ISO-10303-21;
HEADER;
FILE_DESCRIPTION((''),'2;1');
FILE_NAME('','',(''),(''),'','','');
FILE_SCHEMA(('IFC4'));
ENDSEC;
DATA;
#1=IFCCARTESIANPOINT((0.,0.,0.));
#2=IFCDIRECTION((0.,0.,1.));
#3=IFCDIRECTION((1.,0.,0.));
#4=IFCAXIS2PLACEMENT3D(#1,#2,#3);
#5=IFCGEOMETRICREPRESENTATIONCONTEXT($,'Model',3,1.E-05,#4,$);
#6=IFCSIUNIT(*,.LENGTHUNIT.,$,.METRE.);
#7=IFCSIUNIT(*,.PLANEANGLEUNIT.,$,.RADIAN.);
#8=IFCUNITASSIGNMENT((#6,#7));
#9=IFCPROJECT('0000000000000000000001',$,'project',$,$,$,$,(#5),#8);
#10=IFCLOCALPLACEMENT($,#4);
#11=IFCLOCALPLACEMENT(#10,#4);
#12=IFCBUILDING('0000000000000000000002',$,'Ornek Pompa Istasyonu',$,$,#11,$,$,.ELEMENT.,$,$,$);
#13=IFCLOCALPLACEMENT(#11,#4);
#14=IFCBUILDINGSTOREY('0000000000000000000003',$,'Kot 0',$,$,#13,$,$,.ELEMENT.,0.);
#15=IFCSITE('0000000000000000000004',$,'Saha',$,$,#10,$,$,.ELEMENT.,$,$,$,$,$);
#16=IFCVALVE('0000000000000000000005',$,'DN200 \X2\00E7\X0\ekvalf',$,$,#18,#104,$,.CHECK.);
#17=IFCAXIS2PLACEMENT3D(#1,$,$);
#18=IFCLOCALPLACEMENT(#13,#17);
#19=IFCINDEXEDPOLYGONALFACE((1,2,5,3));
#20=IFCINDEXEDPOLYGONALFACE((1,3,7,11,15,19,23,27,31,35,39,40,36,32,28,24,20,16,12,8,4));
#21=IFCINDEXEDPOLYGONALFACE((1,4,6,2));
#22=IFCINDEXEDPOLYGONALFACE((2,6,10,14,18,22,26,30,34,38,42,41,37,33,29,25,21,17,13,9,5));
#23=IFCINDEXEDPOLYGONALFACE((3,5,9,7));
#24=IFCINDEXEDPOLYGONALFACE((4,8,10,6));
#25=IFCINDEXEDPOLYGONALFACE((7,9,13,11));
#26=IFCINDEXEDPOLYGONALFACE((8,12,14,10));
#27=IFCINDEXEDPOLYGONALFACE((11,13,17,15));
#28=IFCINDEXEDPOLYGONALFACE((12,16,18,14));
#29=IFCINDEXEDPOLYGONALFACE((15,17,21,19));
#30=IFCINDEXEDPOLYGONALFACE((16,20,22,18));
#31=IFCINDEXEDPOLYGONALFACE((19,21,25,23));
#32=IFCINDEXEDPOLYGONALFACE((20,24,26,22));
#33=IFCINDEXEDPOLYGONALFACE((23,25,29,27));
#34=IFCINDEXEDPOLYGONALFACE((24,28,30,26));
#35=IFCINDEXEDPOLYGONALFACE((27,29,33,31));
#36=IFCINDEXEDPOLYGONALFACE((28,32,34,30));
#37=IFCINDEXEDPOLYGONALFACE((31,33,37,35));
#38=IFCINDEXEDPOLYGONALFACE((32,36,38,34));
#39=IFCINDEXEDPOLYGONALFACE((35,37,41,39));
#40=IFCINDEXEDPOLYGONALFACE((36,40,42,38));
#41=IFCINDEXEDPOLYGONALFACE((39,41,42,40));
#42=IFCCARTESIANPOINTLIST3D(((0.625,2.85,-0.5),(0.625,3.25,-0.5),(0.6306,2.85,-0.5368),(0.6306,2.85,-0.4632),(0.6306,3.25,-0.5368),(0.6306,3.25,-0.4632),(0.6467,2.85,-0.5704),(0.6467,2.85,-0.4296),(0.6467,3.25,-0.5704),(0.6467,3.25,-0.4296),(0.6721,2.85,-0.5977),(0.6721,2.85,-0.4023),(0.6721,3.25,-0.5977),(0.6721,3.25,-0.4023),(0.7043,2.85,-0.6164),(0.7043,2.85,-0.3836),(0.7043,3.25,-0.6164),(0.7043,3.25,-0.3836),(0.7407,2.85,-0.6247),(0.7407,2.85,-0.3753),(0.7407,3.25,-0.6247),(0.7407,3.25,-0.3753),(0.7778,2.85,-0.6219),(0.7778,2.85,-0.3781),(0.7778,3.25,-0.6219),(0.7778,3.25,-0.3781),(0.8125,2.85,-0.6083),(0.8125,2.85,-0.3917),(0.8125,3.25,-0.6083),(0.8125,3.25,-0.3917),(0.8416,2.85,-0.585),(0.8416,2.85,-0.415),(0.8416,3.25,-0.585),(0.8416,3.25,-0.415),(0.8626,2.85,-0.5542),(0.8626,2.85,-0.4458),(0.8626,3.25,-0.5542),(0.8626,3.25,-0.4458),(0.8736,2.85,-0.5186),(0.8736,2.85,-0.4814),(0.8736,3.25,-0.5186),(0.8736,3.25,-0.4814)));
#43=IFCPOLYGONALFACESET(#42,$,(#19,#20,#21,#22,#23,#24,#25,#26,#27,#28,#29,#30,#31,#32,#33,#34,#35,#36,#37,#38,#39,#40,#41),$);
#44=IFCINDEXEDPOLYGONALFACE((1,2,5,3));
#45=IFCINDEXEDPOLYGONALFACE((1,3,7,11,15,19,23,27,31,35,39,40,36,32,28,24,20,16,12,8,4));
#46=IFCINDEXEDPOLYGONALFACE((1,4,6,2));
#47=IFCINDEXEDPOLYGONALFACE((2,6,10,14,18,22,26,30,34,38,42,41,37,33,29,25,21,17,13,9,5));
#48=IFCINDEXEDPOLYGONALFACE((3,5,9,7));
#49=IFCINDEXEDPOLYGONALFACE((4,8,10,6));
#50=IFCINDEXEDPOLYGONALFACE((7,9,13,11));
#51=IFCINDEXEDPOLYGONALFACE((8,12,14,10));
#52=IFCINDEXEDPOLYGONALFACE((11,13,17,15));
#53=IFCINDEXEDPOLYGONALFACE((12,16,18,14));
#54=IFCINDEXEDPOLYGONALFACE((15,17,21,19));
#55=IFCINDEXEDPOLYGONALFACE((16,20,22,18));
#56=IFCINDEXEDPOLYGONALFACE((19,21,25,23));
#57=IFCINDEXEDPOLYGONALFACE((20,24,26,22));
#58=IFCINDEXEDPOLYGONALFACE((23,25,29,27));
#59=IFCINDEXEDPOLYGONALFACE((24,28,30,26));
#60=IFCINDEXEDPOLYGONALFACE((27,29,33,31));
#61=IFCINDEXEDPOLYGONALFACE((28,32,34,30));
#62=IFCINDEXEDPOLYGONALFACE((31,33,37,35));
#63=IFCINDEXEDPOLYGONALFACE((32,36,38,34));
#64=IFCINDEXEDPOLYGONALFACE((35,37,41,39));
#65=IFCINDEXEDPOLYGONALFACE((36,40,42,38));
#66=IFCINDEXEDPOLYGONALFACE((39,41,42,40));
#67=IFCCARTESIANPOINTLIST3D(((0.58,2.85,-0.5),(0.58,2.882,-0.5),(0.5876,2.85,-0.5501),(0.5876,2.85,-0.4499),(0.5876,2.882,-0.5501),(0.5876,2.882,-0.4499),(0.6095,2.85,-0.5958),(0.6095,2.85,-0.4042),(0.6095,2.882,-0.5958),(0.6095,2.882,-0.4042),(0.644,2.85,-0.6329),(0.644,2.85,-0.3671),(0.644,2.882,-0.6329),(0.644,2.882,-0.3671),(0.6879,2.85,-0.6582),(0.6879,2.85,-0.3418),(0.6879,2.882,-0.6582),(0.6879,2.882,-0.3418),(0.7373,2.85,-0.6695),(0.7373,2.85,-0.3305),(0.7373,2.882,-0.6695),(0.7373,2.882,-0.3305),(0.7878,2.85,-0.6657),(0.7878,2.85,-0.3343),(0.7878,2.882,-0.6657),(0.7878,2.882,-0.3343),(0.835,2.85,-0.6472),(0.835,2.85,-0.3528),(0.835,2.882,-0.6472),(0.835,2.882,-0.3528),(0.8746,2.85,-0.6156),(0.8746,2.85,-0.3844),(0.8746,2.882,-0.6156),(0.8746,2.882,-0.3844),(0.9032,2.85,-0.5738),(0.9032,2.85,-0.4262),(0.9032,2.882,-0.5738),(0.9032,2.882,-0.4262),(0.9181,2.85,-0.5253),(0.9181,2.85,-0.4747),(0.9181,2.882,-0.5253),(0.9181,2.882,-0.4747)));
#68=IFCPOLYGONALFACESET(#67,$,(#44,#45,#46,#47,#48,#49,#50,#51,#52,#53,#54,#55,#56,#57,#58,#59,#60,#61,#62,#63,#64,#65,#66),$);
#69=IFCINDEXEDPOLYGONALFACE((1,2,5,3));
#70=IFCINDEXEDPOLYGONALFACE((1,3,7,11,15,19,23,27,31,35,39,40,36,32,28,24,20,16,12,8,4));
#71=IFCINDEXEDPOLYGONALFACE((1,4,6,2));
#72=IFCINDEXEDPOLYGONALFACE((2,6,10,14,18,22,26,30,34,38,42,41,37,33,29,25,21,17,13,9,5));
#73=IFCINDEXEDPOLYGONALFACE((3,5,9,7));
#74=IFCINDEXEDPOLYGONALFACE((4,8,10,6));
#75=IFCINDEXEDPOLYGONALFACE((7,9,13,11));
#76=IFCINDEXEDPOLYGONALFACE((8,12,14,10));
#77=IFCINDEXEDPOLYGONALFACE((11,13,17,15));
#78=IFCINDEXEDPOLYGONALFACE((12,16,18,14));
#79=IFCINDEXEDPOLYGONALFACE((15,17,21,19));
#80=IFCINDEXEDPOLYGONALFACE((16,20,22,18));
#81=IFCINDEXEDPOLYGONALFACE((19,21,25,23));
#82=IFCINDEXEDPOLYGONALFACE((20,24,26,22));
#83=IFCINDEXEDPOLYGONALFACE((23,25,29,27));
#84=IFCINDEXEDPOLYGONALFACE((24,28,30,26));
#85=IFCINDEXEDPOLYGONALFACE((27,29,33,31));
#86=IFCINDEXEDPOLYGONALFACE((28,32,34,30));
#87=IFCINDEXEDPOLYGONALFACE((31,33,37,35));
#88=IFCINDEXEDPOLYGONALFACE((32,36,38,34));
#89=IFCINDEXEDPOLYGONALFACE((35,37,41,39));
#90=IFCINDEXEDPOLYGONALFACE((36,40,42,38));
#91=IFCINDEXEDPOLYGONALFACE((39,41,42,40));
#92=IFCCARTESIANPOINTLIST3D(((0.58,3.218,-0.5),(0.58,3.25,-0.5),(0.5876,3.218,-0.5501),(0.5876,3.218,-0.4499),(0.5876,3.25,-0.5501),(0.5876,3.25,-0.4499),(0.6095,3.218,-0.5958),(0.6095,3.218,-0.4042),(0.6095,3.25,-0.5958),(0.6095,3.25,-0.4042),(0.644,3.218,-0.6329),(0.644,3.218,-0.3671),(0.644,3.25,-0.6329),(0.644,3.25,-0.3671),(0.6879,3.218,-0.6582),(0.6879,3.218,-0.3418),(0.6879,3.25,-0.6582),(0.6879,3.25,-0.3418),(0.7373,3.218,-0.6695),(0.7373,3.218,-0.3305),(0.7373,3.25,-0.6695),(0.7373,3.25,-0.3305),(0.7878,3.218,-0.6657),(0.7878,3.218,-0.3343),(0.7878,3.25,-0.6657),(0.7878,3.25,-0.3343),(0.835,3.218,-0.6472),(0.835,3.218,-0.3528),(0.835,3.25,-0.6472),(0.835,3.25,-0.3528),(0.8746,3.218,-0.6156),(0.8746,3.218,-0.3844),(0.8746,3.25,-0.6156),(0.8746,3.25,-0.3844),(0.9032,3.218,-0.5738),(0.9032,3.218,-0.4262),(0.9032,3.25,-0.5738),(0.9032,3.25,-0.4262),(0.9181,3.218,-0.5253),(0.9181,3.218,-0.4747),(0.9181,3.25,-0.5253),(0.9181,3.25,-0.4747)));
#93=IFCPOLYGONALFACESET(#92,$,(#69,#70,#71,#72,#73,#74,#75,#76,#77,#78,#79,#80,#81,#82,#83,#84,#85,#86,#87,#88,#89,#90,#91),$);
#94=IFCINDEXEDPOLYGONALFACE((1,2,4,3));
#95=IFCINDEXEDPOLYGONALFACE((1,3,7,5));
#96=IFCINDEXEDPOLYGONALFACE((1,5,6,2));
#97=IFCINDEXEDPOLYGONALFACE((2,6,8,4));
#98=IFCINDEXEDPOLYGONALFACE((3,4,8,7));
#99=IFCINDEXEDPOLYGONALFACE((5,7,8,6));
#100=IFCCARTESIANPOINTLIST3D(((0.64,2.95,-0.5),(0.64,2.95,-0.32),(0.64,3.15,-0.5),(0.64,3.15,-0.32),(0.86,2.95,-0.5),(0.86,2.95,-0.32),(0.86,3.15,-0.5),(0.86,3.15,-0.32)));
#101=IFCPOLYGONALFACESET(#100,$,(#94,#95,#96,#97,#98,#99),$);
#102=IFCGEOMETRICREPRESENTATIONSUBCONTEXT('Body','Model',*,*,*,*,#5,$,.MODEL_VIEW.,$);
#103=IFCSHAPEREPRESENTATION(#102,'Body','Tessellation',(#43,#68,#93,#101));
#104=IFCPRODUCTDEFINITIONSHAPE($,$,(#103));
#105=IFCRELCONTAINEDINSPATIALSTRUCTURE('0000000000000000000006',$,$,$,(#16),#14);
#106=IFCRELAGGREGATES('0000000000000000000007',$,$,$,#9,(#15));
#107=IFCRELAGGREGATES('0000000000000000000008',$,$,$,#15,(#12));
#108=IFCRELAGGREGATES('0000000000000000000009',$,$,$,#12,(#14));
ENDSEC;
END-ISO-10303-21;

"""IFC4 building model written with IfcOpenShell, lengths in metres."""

from ifc_helpers import new_model, si_unit, frame, origin_with_axes, origin_2d, place, context, subcontext, project, spatial, polyline, circle, outline, extrude, element, save


model = new_model("IFC4")

# Units and contexts
model_context = context("Model", 3, precision=1e-05, world=origin_with_axes())
body_context = subcontext(model_context, "Body", "Model", "MODEL_VIEW")
ifc_project = project(units=[si_unit("LENGTHUNIT", "METRE"), si_unit("PLANEANGLEUNIT", "RADIAN")], contexts=[model_context])

# Site, building, storey
site_placement = place(None, origin_with_axes())
site = spatial("IfcSite", under=ifc_project, at=site_placement, Name="Saha", CompositionType="ELEMENT")
building_placement = place(site_placement, origin_with_axes())
building = spatial("IfcBuilding", under=site, at=building_placement, Name="Ornek Pompa Istasyonu", CompositionType="ELEMENT")
storey_placement = place(building_placement, origin_with_axes())
storey = spatial("IfcBuildingStorey", under=building, at=storey_placement, Name="Kot 0", CompositionType="ELEMENT", Elevation=0.0)

# Valve
valve_1_placement = place(storey_placement, origin_with_axes())
element("IfcValve", 1, at=valve_1_placement, inside=storey, Name="DN200 çekvalf", PredefinedType="CHECK", context=body_context, shape_type="SweptSolid", body=[
    extrude(circle(Radius=0.125, at=origin_2d()), frame((0.75, 2.85, -0.5), z_axis=(0.0, 1.0, 0.0), x_axis=(-1.0, 0.0, 0.0)), (0.0, 0.0, 1.0), 0.4),
    extrude(circle(Radius=0.17, at=origin_2d()), frame((0.75, 2.85, -0.5), z_axis=(0.0, 1.0, 0.0), x_axis=(-1.0, 0.0, 0.0)), (0.0, 0.0, 1.0), 0.032),
    extrude(circle(Radius=0.17, at=origin_2d()), frame((0.75, 3.218, -0.5), z_axis=(0.0, 1.0, 0.0), x_axis=(-1.0, 0.0, 0.0)), (0.0, 0.0, 1.0), 0.032),
    extrude(outline(polyline([(0.0, 0.0), (0.2, 0.0), (0.2, 0.22), (0.0, 0.22), (0.0, 0.0)])), frame((0.86, 2.95, -0.5), z_axis=(0.0, 0.0, 1.0), x_axis=(0.0, 1.0, 0.0)), (0.0, 0.0, 1.0), 0.18),
])

save(model, "model.ifc")
